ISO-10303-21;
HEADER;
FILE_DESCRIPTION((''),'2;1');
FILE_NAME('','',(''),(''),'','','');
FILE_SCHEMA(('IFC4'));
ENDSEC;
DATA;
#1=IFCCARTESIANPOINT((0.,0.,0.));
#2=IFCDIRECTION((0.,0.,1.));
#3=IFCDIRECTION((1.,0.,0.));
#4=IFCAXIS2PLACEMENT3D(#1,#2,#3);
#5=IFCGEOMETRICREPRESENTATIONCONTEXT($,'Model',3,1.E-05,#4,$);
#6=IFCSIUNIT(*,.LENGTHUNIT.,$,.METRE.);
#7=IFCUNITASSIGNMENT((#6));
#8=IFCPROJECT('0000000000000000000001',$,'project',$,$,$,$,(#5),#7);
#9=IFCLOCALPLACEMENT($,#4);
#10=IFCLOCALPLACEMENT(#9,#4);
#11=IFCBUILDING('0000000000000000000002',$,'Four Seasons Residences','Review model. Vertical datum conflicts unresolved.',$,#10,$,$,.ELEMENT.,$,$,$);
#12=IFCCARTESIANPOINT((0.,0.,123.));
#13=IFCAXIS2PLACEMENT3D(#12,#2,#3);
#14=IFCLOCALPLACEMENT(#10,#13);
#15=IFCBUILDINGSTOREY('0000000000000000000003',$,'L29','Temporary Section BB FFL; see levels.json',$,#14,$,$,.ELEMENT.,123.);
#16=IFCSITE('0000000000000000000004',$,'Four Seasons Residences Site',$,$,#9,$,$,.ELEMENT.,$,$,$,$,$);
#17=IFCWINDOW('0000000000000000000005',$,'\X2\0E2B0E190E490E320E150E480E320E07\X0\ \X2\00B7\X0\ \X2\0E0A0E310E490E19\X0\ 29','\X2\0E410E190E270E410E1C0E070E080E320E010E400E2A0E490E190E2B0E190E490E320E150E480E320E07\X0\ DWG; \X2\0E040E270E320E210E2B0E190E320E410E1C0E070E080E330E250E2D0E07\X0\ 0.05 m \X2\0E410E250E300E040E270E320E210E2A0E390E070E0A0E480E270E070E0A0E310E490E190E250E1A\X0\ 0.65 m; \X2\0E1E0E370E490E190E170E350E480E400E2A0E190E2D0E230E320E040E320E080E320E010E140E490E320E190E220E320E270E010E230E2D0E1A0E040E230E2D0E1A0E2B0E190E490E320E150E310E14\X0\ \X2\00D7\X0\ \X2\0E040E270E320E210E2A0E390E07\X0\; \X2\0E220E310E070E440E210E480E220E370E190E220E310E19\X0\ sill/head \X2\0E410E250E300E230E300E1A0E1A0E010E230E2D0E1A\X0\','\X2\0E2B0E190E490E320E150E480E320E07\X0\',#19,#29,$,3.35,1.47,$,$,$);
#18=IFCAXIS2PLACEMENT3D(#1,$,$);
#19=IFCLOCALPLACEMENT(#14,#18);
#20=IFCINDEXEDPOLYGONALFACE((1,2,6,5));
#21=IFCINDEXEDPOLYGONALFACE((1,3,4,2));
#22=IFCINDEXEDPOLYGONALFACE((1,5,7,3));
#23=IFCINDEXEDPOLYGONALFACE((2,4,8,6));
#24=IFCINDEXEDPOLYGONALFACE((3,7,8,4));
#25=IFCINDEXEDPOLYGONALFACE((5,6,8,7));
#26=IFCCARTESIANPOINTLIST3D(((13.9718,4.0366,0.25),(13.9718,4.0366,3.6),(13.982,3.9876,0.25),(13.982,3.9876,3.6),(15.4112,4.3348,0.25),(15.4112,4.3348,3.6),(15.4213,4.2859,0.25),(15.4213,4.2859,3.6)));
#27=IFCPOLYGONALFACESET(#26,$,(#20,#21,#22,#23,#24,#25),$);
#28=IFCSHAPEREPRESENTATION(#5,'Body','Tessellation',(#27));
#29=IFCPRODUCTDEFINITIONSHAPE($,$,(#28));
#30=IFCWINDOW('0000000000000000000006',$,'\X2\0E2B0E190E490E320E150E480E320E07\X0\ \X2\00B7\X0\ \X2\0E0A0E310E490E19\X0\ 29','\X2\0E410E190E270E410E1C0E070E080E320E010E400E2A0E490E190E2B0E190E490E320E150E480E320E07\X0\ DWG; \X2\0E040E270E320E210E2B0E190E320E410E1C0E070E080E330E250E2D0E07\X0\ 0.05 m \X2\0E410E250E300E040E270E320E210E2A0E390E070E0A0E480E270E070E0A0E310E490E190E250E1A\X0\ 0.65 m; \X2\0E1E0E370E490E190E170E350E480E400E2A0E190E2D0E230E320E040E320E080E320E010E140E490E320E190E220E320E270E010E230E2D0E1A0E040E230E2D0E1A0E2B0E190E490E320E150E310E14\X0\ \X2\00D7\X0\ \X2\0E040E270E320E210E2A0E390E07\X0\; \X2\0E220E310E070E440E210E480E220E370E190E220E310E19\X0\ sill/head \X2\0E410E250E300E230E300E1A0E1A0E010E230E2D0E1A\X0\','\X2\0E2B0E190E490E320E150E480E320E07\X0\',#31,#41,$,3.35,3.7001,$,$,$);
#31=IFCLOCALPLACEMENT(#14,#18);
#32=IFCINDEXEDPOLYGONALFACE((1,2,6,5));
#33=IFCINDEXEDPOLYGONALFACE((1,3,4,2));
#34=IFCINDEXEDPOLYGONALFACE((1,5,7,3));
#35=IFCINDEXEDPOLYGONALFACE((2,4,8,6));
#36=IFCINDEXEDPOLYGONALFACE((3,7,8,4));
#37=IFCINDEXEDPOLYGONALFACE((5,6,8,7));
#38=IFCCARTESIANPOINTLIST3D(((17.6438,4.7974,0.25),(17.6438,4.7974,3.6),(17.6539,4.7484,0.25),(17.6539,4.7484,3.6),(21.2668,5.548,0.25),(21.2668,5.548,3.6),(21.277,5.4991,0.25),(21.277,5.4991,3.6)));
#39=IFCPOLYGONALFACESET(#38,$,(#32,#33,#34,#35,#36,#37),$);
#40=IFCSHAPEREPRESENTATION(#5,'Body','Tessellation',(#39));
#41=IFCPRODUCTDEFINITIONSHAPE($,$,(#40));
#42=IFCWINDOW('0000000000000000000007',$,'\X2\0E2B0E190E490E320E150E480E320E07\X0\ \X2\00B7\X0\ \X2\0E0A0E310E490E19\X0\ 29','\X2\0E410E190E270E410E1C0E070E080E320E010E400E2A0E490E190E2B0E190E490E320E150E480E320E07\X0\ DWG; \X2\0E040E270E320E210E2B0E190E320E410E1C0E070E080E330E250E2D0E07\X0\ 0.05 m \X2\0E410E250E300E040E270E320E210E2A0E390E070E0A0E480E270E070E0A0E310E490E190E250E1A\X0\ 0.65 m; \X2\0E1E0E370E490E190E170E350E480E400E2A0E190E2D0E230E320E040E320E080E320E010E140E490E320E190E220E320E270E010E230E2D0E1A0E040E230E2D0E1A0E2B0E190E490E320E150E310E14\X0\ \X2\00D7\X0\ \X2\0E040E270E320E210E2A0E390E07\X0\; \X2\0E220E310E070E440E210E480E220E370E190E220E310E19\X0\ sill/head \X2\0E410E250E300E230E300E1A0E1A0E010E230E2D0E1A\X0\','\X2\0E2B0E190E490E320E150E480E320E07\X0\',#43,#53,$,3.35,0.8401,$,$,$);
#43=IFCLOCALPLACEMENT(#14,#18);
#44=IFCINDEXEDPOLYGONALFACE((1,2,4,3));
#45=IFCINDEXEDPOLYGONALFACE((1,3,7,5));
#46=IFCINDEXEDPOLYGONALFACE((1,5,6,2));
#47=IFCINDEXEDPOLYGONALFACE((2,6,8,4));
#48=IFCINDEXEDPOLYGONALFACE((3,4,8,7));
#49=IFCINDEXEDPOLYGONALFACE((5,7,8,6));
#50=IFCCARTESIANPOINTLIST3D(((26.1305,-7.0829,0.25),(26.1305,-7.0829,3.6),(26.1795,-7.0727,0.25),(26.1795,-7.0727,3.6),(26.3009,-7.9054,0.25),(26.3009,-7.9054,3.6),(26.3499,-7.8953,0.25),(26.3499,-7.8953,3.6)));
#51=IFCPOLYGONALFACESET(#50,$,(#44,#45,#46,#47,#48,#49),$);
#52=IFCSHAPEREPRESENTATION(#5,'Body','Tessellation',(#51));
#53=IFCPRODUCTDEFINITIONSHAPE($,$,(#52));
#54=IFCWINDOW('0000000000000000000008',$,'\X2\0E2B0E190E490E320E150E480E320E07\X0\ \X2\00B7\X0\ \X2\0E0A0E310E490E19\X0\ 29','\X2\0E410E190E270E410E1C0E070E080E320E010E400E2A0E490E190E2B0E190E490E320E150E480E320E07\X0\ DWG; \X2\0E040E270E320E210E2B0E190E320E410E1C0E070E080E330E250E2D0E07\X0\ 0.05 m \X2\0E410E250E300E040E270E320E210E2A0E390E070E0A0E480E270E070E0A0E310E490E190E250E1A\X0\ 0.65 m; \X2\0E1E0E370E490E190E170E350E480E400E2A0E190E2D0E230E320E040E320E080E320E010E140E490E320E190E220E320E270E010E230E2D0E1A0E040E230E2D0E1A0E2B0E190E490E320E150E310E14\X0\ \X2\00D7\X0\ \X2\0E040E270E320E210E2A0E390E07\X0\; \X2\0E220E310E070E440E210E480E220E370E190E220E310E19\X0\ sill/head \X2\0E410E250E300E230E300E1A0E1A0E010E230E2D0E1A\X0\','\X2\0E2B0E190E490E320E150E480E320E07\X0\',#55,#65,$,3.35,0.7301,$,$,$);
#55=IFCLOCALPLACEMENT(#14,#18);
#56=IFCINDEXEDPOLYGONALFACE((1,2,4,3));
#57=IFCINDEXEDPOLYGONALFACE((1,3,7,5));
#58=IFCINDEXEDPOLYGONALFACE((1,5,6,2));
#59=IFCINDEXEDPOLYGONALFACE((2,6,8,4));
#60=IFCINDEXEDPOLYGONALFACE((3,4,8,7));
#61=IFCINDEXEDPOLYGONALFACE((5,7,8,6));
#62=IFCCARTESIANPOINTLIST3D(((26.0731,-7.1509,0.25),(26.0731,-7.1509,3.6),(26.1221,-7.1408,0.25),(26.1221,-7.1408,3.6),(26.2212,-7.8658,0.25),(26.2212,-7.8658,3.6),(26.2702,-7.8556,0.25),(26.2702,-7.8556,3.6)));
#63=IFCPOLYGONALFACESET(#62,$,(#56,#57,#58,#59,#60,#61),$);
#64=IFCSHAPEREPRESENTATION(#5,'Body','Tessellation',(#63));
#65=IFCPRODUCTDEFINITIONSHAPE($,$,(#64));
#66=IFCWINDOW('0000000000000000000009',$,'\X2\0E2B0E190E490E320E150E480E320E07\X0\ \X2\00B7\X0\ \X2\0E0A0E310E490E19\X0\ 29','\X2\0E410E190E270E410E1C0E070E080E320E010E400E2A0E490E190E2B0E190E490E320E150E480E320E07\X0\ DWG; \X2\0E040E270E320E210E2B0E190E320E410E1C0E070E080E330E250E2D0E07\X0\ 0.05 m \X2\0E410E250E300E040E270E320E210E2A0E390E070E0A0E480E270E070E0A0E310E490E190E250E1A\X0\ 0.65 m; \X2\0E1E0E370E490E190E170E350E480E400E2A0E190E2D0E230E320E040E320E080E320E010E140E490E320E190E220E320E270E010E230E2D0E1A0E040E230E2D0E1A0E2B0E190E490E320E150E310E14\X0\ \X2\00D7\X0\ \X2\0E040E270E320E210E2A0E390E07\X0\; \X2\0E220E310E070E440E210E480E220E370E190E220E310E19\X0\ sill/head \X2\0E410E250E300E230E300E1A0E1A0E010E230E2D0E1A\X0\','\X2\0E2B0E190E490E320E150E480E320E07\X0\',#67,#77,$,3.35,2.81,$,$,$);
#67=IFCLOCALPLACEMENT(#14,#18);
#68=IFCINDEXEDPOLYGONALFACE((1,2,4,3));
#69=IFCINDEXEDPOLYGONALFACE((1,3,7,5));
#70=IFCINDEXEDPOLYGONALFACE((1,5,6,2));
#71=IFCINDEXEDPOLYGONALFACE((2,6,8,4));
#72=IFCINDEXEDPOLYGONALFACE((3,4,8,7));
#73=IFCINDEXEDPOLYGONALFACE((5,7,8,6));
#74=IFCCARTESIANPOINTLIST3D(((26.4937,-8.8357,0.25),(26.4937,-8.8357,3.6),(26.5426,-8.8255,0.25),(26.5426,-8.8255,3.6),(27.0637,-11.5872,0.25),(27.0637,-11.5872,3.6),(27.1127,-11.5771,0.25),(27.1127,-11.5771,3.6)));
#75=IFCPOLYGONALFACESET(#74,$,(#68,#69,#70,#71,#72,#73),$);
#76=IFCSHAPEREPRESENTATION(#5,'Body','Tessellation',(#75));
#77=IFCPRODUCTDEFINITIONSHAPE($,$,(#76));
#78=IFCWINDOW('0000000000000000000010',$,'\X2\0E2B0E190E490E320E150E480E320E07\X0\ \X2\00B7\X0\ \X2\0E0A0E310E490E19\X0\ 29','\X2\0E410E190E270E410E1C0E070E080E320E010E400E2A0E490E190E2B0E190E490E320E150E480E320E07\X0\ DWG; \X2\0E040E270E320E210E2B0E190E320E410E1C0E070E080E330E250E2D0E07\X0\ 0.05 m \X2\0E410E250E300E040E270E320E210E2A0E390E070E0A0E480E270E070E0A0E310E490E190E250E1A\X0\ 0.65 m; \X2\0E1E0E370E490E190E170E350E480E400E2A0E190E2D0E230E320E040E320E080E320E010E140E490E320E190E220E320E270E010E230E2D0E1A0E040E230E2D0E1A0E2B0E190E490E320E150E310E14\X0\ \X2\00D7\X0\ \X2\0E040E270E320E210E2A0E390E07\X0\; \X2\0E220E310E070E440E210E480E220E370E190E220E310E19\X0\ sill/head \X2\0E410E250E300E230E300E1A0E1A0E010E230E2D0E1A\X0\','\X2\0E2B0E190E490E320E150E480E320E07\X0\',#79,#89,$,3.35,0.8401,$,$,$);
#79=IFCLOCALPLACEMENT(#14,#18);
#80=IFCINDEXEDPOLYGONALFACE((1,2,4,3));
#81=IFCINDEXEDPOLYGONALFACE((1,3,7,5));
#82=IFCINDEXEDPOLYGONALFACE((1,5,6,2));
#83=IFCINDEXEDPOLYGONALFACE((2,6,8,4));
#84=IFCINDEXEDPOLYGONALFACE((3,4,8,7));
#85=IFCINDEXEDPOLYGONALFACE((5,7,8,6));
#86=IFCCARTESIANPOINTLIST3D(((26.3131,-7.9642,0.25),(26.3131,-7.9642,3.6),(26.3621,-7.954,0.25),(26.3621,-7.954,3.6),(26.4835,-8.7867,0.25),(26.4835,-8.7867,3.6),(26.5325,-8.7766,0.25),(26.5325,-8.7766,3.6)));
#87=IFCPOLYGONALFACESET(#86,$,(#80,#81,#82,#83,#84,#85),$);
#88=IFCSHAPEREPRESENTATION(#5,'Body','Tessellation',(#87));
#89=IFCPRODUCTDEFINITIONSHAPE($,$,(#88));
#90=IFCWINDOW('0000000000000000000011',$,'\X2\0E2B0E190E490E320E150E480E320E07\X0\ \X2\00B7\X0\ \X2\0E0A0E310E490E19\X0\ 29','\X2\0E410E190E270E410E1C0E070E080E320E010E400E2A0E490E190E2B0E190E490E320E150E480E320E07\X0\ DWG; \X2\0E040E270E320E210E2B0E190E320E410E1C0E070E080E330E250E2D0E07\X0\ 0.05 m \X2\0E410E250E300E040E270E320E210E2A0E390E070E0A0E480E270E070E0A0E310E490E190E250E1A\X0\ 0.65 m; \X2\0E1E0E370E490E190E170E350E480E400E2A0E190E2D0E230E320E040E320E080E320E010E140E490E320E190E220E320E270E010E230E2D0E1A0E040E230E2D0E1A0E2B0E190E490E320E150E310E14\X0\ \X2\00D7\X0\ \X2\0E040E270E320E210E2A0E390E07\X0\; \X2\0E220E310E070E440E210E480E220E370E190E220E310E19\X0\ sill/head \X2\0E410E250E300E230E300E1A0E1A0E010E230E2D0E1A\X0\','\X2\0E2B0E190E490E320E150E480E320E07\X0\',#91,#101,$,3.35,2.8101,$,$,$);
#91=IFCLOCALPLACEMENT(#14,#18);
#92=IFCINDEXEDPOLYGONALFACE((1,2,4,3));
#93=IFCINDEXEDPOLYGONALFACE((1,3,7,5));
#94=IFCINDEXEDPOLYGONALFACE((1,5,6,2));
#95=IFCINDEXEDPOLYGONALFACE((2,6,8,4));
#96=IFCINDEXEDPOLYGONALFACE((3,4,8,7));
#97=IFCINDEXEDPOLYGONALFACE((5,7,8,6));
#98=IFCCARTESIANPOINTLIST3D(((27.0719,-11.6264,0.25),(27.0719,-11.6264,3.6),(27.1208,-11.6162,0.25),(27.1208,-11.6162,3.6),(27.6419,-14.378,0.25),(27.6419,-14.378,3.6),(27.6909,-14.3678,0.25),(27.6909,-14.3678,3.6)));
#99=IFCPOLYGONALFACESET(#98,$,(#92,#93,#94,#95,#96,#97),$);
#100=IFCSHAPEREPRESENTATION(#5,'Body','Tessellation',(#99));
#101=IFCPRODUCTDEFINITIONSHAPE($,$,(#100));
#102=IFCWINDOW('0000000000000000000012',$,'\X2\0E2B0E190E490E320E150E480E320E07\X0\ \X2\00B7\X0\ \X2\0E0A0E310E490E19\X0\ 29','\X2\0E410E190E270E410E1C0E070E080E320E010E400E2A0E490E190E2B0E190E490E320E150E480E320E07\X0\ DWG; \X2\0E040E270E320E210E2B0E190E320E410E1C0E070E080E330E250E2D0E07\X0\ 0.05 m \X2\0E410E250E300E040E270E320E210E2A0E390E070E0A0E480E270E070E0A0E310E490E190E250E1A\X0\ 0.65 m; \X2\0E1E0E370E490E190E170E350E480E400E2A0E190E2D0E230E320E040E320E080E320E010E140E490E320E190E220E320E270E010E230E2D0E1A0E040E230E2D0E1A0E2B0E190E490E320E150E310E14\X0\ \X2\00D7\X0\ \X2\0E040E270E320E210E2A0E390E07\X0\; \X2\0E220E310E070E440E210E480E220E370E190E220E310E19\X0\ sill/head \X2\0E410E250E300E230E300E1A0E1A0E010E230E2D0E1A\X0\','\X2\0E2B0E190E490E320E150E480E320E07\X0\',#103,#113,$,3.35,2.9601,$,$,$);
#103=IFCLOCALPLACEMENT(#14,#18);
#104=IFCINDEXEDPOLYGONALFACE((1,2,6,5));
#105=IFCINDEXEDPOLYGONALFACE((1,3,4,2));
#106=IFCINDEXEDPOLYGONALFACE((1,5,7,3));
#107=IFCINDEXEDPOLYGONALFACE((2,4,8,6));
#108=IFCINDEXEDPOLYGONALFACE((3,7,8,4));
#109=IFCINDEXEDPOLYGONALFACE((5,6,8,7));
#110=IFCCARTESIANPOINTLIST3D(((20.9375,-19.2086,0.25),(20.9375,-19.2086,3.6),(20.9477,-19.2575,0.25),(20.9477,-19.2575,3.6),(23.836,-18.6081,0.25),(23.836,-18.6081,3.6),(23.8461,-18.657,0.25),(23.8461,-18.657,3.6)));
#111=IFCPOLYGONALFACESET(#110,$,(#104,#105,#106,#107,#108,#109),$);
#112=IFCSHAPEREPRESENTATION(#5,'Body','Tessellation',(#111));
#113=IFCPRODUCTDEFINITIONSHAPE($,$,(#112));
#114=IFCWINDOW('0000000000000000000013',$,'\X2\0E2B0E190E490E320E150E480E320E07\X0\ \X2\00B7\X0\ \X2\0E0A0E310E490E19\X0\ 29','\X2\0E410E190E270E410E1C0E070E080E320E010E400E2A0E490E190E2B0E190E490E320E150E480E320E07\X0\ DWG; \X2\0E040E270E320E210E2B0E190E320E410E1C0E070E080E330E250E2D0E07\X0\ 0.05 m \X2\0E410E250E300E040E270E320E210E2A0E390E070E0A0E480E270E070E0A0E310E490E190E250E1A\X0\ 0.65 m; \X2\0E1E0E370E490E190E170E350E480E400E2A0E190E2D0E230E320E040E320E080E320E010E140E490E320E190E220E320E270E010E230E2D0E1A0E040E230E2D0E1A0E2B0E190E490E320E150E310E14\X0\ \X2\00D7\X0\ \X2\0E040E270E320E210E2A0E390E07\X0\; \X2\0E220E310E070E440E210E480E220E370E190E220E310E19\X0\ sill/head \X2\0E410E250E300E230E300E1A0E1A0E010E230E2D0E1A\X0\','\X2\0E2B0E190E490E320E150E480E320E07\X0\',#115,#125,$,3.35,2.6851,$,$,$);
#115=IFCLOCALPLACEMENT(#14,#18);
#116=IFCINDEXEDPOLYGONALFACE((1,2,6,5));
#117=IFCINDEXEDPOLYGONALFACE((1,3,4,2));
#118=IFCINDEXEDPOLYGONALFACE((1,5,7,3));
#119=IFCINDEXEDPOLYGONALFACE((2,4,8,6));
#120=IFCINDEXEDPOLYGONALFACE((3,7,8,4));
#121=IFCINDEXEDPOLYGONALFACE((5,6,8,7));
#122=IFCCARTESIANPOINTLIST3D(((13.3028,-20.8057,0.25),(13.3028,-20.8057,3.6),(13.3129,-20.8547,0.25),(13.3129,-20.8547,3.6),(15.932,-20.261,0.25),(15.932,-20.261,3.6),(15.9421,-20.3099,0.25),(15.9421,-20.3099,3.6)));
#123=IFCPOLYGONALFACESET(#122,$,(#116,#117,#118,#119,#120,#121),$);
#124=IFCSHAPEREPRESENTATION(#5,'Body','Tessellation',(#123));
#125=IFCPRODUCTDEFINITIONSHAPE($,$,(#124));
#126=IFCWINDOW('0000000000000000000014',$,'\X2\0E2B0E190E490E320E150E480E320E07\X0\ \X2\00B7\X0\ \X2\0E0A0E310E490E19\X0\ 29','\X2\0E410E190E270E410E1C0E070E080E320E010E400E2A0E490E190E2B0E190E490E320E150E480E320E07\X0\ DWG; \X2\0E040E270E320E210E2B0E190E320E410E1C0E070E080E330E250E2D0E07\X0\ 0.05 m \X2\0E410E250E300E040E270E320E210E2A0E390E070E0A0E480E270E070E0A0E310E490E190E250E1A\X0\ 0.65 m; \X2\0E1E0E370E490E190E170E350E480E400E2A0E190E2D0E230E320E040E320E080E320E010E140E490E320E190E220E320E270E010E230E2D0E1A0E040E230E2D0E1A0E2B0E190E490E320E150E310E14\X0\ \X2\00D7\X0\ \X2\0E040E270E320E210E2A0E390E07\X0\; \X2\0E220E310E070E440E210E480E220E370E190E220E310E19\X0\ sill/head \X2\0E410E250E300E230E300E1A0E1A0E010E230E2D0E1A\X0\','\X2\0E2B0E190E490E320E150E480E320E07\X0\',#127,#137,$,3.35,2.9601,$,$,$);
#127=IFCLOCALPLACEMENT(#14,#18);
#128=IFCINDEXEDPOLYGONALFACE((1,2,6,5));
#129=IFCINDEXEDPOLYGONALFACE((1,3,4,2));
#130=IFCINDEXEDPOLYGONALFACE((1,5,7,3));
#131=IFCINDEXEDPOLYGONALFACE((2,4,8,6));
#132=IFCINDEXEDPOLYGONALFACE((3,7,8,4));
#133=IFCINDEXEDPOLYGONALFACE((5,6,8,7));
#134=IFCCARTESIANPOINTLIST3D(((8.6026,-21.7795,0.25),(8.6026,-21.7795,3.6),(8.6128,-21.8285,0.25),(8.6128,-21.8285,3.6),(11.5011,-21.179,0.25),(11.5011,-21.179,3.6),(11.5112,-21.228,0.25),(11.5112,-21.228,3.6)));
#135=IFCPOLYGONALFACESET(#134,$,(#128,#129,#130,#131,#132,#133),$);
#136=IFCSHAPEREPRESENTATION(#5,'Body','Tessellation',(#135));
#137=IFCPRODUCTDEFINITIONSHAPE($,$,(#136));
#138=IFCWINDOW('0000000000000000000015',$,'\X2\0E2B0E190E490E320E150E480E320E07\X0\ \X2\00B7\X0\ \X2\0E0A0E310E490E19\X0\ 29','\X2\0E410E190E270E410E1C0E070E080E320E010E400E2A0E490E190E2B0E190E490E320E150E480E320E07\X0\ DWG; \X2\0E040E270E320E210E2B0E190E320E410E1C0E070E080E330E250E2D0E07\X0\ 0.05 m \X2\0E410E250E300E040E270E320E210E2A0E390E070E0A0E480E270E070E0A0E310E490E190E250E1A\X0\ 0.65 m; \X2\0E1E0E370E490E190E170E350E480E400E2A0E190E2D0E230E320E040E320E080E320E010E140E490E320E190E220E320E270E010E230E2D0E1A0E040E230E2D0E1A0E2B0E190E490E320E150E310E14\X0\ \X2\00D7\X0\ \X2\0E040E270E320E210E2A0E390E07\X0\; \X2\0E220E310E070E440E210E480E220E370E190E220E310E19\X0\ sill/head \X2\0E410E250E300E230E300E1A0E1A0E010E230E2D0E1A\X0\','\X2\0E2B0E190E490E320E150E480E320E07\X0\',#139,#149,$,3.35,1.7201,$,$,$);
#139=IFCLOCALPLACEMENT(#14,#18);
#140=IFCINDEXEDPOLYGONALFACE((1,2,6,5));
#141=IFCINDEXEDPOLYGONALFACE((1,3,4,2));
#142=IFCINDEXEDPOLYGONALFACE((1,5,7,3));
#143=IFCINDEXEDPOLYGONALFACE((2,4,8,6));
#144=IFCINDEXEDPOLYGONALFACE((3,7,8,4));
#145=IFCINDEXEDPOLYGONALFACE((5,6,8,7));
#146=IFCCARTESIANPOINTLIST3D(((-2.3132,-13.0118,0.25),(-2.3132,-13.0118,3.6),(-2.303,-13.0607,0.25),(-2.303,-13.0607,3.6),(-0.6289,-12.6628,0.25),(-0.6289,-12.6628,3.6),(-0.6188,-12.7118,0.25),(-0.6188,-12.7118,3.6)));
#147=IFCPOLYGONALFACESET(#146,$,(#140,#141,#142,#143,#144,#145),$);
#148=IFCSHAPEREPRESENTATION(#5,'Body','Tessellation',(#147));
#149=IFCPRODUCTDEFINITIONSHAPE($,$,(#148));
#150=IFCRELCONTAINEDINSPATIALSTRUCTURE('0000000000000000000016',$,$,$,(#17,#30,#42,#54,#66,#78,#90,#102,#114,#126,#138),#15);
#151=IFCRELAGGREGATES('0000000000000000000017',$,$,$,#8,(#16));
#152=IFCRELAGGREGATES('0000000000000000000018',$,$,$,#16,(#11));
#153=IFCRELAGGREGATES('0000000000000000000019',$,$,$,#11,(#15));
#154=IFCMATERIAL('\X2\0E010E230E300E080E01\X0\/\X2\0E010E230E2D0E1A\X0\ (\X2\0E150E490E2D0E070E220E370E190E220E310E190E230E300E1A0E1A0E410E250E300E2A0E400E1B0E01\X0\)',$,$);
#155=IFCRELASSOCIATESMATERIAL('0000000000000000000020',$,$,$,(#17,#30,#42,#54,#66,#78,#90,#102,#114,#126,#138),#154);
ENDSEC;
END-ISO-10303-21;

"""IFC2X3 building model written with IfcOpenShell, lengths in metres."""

from ifc_helpers import new_model, si_unit, frame, origin_with_axes, place, context, project, spatial, polyline, outline, extrude, material, element, save


model = new_model("IFC2X3")

# Units and contexts
model_context = context("Model", 3, precision=1e-05, world=origin_with_axes())
ifc_project = project(units=[si_unit("LENGTHUNIT", "METRE")], contexts=[model_context])

# Site, building, storey
site_placement = place(None, origin_with_axes())
site = spatial("IfcSite", under=ifc_project, at=site_placement, Name="Four Seasons Residences Site", CompositionType="ELEMENT")
building_placement = place(site_placement, origin_with_axes())
building = spatial("IfcBuilding", under=site, at=building_placement, Name="Four Seasons Residences", Description="Review model. Vertical datum conflicts unresolved.", CompositionType="ELEMENT")
storey_placement = place(building_placement, frame((0.0, 0.0, 123.0), z_axis=(0.0, 0.0, 1.0), x_axis=(1.0, 0.0, 0.0)))
storey = spatial("IfcBuildingStorey", under=building, at=storey_placement, Name="L29", Description="Temporary Section BB FFL; see levels.json", CompositionType="ELEMENT", Elevation=123.0)

# Windows
ifc_material_1 = material(Name="กระจก/กรอบ (ต้องยืนยันระบบและสเปก)")
window_1_placement = place(storey_placement, origin_with_axes())
element("IfcWindow", 1, at=window_1_placement, inside=storey, material=ifc_material_1, Name="หน้าต่าง · ชั้น 29", Description="แนวแผงจากเส้นหน้าต่าง DWG; ความหนาแผงจำลอง 0.05 m และความสูงช่วงชั้นลบ 0.65 m; พื้นที่เสนอราคาจากด้านยาวกรอบครอบหน้าตัด × ความสูง; ยังไม่ยืนยัน sill/head และระบบกรอบ", ObjectType="หน้าต่าง", OverallHeight=3.35, OverallWidth=1.47, context=model_context, shape_type="SweptSolid", body=[
    extrude(outline(polyline([(13.982, 3.9876), (13.9718, 4.0366), (15.4112, 4.3348), (15.4213, 4.2859), (13.982, 3.9876)])), frame((0.0, 0.0, 0.25), z_axis=(0.0, 0.0, 1.0), x_axis=(1.0, 0.0, 0.0)), (0.0, 0.0, 1.0), 3.35),
])
window_2_placement = place(storey_placement, origin_with_axes())
element("IfcWindow", 2, at=window_2_placement, inside=storey, material=ifc_material_1, Name="หน้าต่าง · ชั้น 29", Description="แนวแผงจากเส้นหน้าต่าง DWG; ความหนาแผงจำลอง 0.05 m และความสูงช่วงชั้นลบ 0.65 m; พื้นที่เสนอราคาจากด้านยาวกรอบครอบหน้าตัด × ความสูง; ยังไม่ยืนยัน sill/head และระบบกรอบ", ObjectType="หน้าต่าง", OverallHeight=3.35, OverallWidth=3.7001, context=model_context, shape_type="SweptSolid", body=[
    extrude(outline(polyline([(17.6539, 4.7484), (17.6438, 4.7974), (21.2668, 5.548), (21.277, 5.4991), (17.6539, 4.7484)])), frame((0.0, 0.0, 0.25), z_axis=(0.0, 0.0, 1.0), x_axis=(1.0, 0.0, 0.0)), (0.0, 0.0, 1.0), 3.35),
])
window_3_placement = place(storey_placement, origin_with_axes())
element("IfcWindow", 3, at=window_3_placement, inside=storey, material=ifc_material_1, Name="หน้าต่าง · ชั้น 29", Description="แนวแผงจากเส้นหน้าต่าง DWG; ความหนาแผงจำลอง 0.05 m และความสูงช่วงชั้นลบ 0.65 m; พื้นที่เสนอราคาจากด้านยาวกรอบครอบหน้าตัด × ความสูง; ยังไม่ยืนยัน sill/head และระบบกรอบ", ObjectType="หน้าต่าง", OverallHeight=3.35, OverallWidth=0.8401, context=model_context, shape_type="SweptSolid", body=[
    extrude(outline(polyline([(26.1305, -7.0829), (26.1795, -7.0727), (26.3499, -7.8953), (26.3009, -7.9054), (26.1305, -7.0829)])), frame((0.0, 0.0, 0.25), z_axis=(0.0, 0.0, 1.0), x_axis=(1.0, 0.0, 0.0)), (0.0, 0.0, 1.0), 3.35),
])
window_4_placement = place(storey_placement, origin_with_axes())
element("IfcWindow", 4, at=window_4_placement, inside=storey, material=ifc_material_1, Name="หน้าต่าง · ชั้น 29", Description="แนวแผงจากเส้นหน้าต่าง DWG; ความหนาแผงจำลอง 0.05 m และความสูงช่วงชั้นลบ 0.65 m; พื้นที่เสนอราคาจากด้านยาวกรอบครอบหน้าตัด × ความสูง; ยังไม่ยืนยัน sill/head และระบบกรอบ", ObjectType="หน้าต่าง", OverallHeight=3.35, OverallWidth=0.7301, context=model_context, shape_type="SweptSolid", body=[
    extrude(outline(polyline([(26.0731, -7.1509), (26.1221, -7.1408), (26.2702, -7.8556), (26.2212, -7.8658), (26.0731, -7.1509)])), frame((0.0, 0.0, 0.25), z_axis=(0.0, 0.0, 1.0), x_axis=(1.0, 0.0, 0.0)), (0.0, 0.0, 1.0), 3.35),
])
window_5_placement = place(storey_placement, origin_with_axes())
element("IfcWindow", 5, at=window_5_placement, inside=storey, material=ifc_material_1, Name="หน้าต่าง · ชั้น 29", Description="แนวแผงจากเส้นหน้าต่าง DWG; ความหนาแผงจำลอง 0.05 m และความสูงช่วงชั้นลบ 0.65 m; พื้นที่เสนอราคาจากด้านยาวกรอบครอบหน้าตัด × ความสูง; ยังไม่ยืนยัน sill/head และระบบกรอบ", ObjectType="หน้าต่าง", OverallHeight=3.35, OverallWidth=2.81, context=model_context, shape_type="SweptSolid", body=[
    extrude(outline(polyline([(26.4937, -8.8357), (26.5426, -8.8255), (27.1127, -11.5771), (27.0637, -11.5872), (26.4937, -8.8357)])), frame((0.0, 0.0, 0.25), z_axis=(0.0, 0.0, 1.0), x_axis=(1.0, 0.0, 0.0)), (0.0, 0.0, 1.0), 3.35),
])
window_6_placement = place(storey_placement, origin_with_axes())
element("IfcWindow", 6, at=window_6_placement, inside=storey, material=ifc_material_1, Name="หน้าต่าง · ชั้น 29", Description="แนวแผงจากเส้นหน้าต่าง DWG; ความหนาแผงจำลอง 0.05 m และความสูงช่วงชั้นลบ 0.65 m; พื้นที่เสนอราคาจากด้านยาวกรอบครอบหน้าตัด × ความสูง; ยังไม่ยืนยัน sill/head และระบบกรอบ", ObjectType="หน้าต่าง", OverallHeight=3.35, OverallWidth=0.8401, context=model_context, shape_type="SweptSolid", body=[
    extrude(outline(polyline([(26.3131, -7.9642), (26.3621, -7.954), (26.5325, -8.7766), (26.4835, -8.7867), (26.3131, -7.9642)])), frame((0.0, 0.0, 0.25), z_axis=(0.0, 0.0, 1.0), x_axis=(1.0, 0.0, 0.0)), (0.0, 0.0, 1.0), 3.35),
])
window_7_placement = place(storey_placement, origin_with_axes())
element("IfcWindow", 7, at=window_7_placement, inside=storey, material=ifc_material_1, Name="หน้าต่าง · ชั้น 29", Description="แนวแผงจากเส้นหน้าต่าง DWG; ความหนาแผงจำลอง 0.05 m และความสูงช่วงชั้นลบ 0.65 m; พื้นที่เสนอราคาจากด้านยาวกรอบครอบหน้าตัด × ความสูง; ยังไม่ยืนยัน sill/head และระบบกรอบ", ObjectType="หน้าต่าง", OverallHeight=3.35, OverallWidth=2.8101, context=model_context, shape_type="SweptSolid", body=[
    extrude(outline(polyline([(27.0719, -11.6264), (27.1208, -11.6162), (27.6909, -14.3678), (27.6419, -14.378), (27.0719, -11.6264)])), frame((0.0, 0.0, 0.25), z_axis=(0.0, 0.0, 1.0), x_axis=(1.0, 0.0, 0.0)), (0.0, 0.0, 1.0), 3.35),
])
window_8_placement = place(storey_placement, origin_with_axes())
element("IfcWindow", 8, at=window_8_placement, inside=storey, material=ifc_material_1, Name="หน้าต่าง · ชั้น 29", Description="แนวแผงจากเส้นหน้าต่าง DWG; ความหนาแผงจำลอง 0.05 m และความสูงช่วงชั้นลบ 0.65 m; พื้นที่เสนอราคาจากด้านยาวกรอบครอบหน้าตัด × ความสูง; ยังไม่ยืนยัน sill/head และระบบกรอบ", ObjectType="หน้าต่าง", OverallHeight=3.35, OverallWidth=2.9601, context=model_context, shape_type="SweptSolid", body=[
    extrude(outline(polyline([(20.9477, -19.2575), (20.9375, -19.2086), (23.836, -18.6081), (23.8461, -18.657), (20.9477, -19.2575)])), frame((0.0, 0.0, 0.25), z_axis=(0.0, 0.0, 1.0), x_axis=(1.0, 0.0, 0.0)), (0.0, 0.0, 1.0), 3.35),
])
window_9_placement = place(storey_placement, origin_with_axes())
element("IfcWindow", 9, at=window_9_placement, inside=storey, material=ifc_material_1, Name="หน้าต่าง · ชั้น 29", Description="แนวแผงจากเส้นหน้าต่าง DWG; ความหนาแผงจำลอง 0.05 m และความสูงช่วงชั้นลบ 0.65 m; พื้นที่เสนอราคาจากด้านยาวกรอบครอบหน้าตัด × ความสูง; ยังไม่ยืนยัน sill/head และระบบกรอบ", ObjectType="หน้าต่าง", OverallHeight=3.35, OverallWidth=2.6851, context=model_context, shape_type="SweptSolid", body=[
    extrude(outline(polyline([(13.3129, -20.8547), (13.3028, -20.8057), (15.932, -20.261), (15.9421, -20.3099), (13.3129, -20.8547)])), frame((0.0, 0.0, 0.25), z_axis=(0.0, 0.0, 1.0), x_axis=(1.0, 0.0, 0.0)), (0.0, 0.0, 1.0), 3.35),
])
window_10_placement = place(storey_placement, origin_with_axes())
element("IfcWindow", 10, at=window_10_placement, inside=storey, material=ifc_material_1, Name="หน้าต่าง · ชั้น 29", Description="แนวแผงจากเส้นหน้าต่าง DWG; ความหนาแผงจำลอง 0.05 m และความสูงช่วงชั้นลบ 0.65 m; พื้นที่เสนอราคาจากด้านยาวกรอบครอบหน้าตัด × ความสูง; ยังไม่ยืนยัน sill/head และระบบกรอบ", ObjectType="หน้าต่าง", OverallHeight=3.35, OverallWidth=2.9601, context=model_context, shape_type="SweptSolid", body=[
    extrude(outline(polyline([(8.6128, -21.8285), (8.6026, -21.7795), (11.5011, -21.179), (11.5112, -21.228), (8.6128, -21.8285)])), frame((0.0, 0.0, 0.25), z_axis=(0.0, 0.0, 1.0), x_axis=(1.0, 0.0, 0.0)), (0.0, 0.0, 1.0), 3.35),
])
window_11_placement = place(storey_placement, origin_with_axes())
element("IfcWindow", 11, at=window_11_placement, inside=storey, material=ifc_material_1, Name="หน้าต่าง · ชั้น 29", Description="แนวแผงจากเส้นหน้าต่าง DWG; ความหนาแผงจำลอง 0.05 m และความสูงช่วงชั้นลบ 0.65 m; พื้นที่เสนอราคาจากด้านยาวกรอบครอบหน้าตัด × ความสูง; ยังไม่ยืนยัน sill/head และระบบกรอบ", ObjectType="หน้าต่าง", OverallHeight=3.35, OverallWidth=1.7201, context=model_context, shape_type="SweptSolid", body=[
    extrude(outline(polyline([(-0.6289, -12.6628), (-0.6188, -12.7118), (-2.303, -13.0607), (-2.3132, -13.0118), (-0.6289, -12.6628)])), frame((0.0, 0.0, 0.25), z_axis=(0.0, 0.0, 1.0), x_axis=(1.0, 0.0, 0.0)), (0.0, 0.0, 1.0), 3.35),
])

save(model, "model.ifc")
